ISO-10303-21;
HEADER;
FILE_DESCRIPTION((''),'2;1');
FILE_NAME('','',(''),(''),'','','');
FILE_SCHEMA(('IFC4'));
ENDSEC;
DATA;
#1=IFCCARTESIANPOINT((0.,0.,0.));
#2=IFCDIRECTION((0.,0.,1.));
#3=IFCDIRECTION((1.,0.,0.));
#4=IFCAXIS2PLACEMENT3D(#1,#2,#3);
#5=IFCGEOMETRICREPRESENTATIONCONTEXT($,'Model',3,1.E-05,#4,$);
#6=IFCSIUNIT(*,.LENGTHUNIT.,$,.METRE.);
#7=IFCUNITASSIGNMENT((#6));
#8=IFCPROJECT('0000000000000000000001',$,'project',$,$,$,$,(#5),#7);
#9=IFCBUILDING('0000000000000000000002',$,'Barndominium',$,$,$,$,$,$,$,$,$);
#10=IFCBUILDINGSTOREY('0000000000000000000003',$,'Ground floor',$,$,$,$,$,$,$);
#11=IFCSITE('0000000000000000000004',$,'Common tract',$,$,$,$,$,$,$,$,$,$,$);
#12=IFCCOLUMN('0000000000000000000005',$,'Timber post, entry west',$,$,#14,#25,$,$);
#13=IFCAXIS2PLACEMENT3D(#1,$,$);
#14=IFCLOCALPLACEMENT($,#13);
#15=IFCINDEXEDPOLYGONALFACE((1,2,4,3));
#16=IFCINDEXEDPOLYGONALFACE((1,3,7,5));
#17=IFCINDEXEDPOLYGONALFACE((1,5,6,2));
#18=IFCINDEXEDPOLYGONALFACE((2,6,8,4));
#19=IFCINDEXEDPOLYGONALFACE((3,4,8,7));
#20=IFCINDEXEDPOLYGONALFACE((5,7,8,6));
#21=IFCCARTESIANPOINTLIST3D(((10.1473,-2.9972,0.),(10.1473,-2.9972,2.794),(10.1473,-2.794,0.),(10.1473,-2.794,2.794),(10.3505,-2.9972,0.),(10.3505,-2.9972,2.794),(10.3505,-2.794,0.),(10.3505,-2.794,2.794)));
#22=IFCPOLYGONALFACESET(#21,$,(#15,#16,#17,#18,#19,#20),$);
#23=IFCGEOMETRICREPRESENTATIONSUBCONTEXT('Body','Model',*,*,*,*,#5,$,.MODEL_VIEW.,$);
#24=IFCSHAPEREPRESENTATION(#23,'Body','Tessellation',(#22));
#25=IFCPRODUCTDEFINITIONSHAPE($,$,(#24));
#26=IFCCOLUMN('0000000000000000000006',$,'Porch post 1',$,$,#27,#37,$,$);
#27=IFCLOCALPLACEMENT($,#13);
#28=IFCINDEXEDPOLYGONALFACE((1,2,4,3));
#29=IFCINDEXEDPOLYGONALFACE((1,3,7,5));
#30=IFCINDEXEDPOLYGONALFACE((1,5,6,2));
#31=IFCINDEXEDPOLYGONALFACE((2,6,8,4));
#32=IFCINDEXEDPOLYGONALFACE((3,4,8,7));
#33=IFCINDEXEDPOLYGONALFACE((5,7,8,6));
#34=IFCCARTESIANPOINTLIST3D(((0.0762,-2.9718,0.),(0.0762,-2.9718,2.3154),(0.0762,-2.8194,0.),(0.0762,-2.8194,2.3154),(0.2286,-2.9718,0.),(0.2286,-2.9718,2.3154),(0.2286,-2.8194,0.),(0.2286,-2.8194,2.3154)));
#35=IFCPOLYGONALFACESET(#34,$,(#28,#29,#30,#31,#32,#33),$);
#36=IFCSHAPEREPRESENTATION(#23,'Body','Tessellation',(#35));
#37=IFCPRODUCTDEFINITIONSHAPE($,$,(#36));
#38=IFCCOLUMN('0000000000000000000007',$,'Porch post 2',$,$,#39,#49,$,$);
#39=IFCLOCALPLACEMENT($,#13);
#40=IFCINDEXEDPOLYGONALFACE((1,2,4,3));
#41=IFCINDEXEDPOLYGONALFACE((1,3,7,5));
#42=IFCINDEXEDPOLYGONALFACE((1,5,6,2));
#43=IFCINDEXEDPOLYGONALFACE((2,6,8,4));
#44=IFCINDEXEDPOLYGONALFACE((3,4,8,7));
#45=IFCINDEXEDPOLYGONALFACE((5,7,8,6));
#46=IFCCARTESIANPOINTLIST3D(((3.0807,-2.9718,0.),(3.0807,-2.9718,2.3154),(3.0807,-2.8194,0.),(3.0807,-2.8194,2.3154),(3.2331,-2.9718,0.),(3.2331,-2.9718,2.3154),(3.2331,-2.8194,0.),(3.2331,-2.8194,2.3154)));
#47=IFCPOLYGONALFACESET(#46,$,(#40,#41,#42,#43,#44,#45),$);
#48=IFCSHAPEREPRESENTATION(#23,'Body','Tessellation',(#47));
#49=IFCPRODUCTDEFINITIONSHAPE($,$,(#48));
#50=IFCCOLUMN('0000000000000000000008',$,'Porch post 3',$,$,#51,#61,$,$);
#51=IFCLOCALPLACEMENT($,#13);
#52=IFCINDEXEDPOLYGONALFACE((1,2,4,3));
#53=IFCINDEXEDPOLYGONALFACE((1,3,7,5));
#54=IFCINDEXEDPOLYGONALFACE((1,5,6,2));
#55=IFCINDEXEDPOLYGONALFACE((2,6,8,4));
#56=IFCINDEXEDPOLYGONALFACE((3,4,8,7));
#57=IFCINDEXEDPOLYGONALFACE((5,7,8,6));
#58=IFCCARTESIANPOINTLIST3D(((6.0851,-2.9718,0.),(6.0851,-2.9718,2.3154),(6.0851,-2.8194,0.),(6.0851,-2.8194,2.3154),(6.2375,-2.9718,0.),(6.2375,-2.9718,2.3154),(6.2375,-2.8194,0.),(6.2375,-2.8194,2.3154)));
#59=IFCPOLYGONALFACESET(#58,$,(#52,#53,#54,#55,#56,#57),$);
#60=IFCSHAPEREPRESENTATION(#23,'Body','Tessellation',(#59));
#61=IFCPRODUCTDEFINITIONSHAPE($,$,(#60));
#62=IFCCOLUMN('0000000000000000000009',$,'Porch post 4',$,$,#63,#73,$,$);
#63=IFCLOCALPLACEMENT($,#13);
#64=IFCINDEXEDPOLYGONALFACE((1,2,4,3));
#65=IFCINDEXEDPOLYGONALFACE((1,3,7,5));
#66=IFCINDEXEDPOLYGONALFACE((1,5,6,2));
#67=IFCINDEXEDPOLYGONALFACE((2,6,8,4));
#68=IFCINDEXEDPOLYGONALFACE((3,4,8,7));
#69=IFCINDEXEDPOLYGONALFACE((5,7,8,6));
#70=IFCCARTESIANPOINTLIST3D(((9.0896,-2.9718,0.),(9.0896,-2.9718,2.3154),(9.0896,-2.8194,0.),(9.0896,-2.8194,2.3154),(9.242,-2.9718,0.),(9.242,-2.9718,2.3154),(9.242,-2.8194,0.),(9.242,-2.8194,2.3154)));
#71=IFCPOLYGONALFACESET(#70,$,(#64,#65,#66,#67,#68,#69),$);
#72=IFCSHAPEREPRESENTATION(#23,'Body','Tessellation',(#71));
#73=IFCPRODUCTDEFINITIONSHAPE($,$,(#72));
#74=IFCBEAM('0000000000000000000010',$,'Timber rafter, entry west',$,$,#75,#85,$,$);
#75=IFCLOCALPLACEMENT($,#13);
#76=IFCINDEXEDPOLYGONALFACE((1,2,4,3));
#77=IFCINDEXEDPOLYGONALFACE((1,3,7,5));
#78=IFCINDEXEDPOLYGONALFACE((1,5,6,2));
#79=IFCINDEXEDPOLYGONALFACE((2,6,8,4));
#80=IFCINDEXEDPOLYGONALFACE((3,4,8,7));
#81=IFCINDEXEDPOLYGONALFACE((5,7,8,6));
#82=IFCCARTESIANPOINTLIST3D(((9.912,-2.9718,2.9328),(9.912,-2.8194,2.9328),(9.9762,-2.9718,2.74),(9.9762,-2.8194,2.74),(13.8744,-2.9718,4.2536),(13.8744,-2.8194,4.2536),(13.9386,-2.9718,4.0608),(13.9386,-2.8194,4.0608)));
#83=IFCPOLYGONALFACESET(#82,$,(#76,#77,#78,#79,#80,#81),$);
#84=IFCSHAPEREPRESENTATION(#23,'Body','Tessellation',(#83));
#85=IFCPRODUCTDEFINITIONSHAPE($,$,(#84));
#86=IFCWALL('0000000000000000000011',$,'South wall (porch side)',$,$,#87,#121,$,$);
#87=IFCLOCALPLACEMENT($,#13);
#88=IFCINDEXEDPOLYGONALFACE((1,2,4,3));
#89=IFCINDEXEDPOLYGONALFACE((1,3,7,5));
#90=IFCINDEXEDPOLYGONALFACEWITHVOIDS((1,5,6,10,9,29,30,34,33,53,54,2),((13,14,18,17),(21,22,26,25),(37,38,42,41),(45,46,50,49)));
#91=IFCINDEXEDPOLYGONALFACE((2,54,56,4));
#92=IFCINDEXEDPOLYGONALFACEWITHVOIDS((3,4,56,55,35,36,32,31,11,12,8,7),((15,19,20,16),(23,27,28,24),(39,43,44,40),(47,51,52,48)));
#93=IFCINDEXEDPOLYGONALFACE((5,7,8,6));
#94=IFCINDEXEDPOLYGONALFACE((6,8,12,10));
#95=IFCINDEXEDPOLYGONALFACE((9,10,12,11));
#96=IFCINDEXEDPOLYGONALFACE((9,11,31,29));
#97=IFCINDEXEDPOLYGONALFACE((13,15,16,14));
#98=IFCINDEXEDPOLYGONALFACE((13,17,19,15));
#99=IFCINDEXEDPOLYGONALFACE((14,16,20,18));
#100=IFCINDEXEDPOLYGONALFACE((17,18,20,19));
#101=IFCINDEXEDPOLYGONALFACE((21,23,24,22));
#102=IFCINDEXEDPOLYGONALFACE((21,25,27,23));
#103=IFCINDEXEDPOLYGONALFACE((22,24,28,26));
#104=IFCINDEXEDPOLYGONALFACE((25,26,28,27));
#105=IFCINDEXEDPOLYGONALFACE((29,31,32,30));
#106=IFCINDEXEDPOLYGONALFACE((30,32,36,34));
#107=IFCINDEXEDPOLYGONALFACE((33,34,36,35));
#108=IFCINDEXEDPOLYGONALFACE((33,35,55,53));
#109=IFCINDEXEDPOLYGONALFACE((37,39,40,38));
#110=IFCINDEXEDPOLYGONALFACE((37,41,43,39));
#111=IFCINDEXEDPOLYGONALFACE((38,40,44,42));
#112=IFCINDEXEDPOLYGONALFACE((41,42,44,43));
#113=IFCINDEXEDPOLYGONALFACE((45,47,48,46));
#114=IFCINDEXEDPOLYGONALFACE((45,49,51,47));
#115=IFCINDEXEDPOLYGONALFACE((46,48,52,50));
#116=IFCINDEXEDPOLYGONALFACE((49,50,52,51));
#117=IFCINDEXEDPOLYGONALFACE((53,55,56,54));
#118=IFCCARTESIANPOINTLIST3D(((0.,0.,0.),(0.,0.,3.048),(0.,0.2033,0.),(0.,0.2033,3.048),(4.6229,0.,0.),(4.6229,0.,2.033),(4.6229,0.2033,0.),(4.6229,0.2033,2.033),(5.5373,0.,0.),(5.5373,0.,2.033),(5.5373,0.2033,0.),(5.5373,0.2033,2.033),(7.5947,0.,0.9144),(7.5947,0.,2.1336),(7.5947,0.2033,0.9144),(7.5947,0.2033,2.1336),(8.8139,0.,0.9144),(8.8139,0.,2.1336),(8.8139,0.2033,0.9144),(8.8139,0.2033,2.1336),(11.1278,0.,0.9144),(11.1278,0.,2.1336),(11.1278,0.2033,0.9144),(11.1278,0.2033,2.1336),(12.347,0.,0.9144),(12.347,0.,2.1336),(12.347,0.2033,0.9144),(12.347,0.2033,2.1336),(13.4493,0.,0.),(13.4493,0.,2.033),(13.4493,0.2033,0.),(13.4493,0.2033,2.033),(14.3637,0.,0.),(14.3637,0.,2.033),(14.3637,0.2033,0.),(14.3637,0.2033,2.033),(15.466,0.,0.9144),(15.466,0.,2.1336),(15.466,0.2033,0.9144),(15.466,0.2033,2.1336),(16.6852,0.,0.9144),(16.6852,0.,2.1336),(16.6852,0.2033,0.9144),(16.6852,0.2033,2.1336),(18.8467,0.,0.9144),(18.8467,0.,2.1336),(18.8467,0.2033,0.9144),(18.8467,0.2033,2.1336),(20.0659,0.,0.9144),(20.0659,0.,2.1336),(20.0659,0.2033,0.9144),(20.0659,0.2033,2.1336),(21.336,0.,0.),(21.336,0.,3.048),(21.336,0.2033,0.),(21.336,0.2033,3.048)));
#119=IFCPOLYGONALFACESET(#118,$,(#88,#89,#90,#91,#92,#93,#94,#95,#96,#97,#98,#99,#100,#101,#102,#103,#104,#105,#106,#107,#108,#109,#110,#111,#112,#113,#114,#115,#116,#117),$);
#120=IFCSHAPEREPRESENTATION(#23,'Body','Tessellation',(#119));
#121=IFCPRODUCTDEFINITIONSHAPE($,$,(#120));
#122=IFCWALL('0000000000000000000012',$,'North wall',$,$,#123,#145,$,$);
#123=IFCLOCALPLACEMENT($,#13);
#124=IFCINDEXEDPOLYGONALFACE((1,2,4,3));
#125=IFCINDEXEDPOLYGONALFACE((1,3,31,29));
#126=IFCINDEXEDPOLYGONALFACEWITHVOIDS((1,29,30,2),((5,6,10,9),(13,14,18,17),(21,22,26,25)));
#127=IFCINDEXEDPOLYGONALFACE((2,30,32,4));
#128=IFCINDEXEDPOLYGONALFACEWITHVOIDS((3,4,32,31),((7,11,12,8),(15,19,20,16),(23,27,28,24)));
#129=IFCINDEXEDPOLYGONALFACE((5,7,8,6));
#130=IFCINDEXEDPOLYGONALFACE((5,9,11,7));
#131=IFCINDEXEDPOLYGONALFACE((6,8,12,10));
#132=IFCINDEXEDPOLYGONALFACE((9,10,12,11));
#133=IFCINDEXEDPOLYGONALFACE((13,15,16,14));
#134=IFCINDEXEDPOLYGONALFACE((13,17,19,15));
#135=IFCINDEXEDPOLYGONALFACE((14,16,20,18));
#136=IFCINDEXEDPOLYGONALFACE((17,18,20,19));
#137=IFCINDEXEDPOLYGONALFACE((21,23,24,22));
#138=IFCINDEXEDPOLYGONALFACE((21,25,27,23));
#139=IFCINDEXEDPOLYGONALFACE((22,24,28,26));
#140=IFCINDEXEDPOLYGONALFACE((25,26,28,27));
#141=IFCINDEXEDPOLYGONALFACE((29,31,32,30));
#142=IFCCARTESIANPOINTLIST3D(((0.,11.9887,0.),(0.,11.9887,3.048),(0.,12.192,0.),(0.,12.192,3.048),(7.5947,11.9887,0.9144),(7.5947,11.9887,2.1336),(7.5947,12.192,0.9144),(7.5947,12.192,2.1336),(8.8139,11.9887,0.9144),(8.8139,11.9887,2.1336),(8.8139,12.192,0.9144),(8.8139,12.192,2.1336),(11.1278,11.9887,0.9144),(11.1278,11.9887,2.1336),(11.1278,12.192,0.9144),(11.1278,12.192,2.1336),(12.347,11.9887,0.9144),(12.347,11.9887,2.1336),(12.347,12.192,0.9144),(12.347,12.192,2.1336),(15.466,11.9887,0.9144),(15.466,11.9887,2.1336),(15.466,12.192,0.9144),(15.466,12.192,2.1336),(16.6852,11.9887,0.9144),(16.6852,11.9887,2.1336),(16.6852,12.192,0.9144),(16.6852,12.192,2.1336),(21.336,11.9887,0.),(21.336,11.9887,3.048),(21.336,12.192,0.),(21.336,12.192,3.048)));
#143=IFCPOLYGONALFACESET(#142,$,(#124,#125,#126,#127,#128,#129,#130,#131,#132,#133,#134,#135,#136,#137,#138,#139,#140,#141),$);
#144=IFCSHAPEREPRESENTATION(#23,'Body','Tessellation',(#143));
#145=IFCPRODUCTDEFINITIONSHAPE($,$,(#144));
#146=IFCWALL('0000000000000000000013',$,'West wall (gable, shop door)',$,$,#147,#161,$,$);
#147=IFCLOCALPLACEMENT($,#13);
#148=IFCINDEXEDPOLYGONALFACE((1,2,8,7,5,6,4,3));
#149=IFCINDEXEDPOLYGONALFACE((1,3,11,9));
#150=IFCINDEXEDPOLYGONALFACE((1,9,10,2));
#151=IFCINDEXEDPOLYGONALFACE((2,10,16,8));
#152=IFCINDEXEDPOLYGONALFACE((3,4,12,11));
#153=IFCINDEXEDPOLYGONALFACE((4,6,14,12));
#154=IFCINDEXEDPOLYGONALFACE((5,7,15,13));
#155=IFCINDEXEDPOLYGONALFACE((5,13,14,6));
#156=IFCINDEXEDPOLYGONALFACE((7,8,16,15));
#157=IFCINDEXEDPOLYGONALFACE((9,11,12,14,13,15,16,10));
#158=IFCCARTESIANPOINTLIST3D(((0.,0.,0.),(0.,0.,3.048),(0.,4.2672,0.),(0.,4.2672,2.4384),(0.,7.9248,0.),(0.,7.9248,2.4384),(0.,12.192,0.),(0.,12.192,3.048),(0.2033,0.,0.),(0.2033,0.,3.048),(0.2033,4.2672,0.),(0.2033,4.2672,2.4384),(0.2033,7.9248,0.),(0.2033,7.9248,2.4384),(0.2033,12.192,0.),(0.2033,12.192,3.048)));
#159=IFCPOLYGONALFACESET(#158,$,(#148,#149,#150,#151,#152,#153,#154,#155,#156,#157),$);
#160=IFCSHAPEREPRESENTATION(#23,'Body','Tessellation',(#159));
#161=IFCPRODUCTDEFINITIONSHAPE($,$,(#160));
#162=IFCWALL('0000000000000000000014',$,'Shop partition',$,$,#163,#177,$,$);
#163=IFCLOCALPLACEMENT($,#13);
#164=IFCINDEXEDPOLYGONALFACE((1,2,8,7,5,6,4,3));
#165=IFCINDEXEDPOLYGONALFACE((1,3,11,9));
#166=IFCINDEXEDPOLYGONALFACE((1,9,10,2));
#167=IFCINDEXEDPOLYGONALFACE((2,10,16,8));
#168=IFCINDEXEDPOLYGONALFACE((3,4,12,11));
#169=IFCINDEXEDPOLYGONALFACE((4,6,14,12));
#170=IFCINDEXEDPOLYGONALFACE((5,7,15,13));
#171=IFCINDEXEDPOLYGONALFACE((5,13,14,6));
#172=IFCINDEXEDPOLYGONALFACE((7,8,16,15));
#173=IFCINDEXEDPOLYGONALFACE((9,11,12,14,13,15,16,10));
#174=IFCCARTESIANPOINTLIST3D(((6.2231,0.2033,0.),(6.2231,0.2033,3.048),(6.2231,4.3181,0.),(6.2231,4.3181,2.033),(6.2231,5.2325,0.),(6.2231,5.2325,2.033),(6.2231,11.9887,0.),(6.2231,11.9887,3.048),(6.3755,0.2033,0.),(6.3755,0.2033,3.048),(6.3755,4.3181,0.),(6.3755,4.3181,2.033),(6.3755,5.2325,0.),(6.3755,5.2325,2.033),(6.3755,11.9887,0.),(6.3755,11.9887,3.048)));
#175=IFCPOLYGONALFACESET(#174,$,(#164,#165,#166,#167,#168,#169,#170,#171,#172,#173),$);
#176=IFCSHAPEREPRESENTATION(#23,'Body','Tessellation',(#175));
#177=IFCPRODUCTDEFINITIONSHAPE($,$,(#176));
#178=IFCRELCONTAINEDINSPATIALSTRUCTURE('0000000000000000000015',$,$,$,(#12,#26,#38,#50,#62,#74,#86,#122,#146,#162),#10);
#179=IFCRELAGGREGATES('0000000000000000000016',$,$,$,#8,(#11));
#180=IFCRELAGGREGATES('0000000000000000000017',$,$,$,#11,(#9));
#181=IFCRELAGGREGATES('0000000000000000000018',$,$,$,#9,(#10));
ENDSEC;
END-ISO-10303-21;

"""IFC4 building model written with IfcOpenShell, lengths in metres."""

from ifc_helpers import new_model, si_unit, frame, origin_with_axes, place, context, subcontext, project, spatial, indexed_curve, rectangle, outline, extrude, element, save


model = new_model("IFC4")

# Units and contexts
model_context = context("Model", 3, precision=1e-05, world=origin_with_axes())
body_context = subcontext(model_context, "Body", "Model", "MODEL_VIEW")
ifc_project = project(units=[si_unit("LENGTHUNIT", "METRE")], contexts=[model_context])

# Site, building, storey
site = spatial("IfcSite", under=ifc_project, Name="Common tract")
building = spatial("IfcBuilding", under=site, Name="Barndominium")
storey = spatial("IfcBuildingStorey", under=building, Name="Ground floor")

# Columns
column_placement = place(None, frame((10.2489, -2.8956, 0.0), z_axis=(0.0, 0.0, 1.0), x_axis=(1.0, 0.0, 0.0)))
element("IfcColumn", 1, at=column_placement, inside=storey, Name="Timber post, entry west", context=body_context, shape_type="SweptSolid", body=[
    extrude(rectangle(XDim=0.2032, YDim=0.2032), origin_with_axes(), (0.0, 0.0, 1.0), 2.794),
])
for number, where, z_axis, x_axis, name in (
    (2, (0.1524, -2.8956, 0.0), (0.0, 0.0, 1.0), (1.0, 0.0, 0.0), "Porch post 1"),
    (3, (3.1569, -2.8956, 0.0), (0.0, 0.0, 1.0), (1.0, 0.0, 0.0), "Porch post 2"),
    (4, (6.1613, -2.8956, 0.0), (0.0, 0.0, 1.0), (1.0, 0.0, 0.0), "Porch post 3"),
    (5, (9.1658, -2.8956, 0.0), (0.0, 0.0, 1.0), (1.0, 0.0, 0.0), "Porch post 4"),
):
    element("IfcColumn", number, at=place(None, frame(where, z_axis=z_axis, x_axis=x_axis)), inside=storey, Name=name, context=body_context, shape_type="SweptSolid", body=[
        extrude(rectangle(XDim=0.1524, YDim=0.1524), origin_with_axes(), (0.0, 0.0, 1.0), 2.3154),
    ])

# Beam
beam_placement = place(None, frame((9.9441, -2.8956, 2.8364), z_axis=(0.948683, 0.0, 0.316228), x_axis=(0.0, 1.0, 0.0)))
element("IfcBeam", 6, at=beam_placement, inside=storey, Name="Timber rafter, entry west", context=body_context, shape_type="SweptSolid", body=[
    extrude(rectangle(XDim=0.1524, YDim=0.2032), origin_with_axes(), (0.0, 0.0, 1.0), 4.1767),
])

# Walls, openings
wall_1_placement = place(None, origin_with_axes())
wall_1 = element("IfcWall", 7, at=wall_1_placement, inside=storey, Name="South wall (porch side)", context=body_context, shape_type="SweptSolid", body=[
    extrude(outline(indexed_curve([(0.0, 0.0), (0.0, 0.2033), (21.336, 0.2033), (21.336, 0.0), (0.0, 0.0)], self_intersect=False)), origin_with_axes(), (0.0, 0.0, 1.0), 3.048),
])
opening_1_placement = place(wall_1_placement, frame((5.0801, 0.1017, 0.0), z_axis=(0.0, 0.0, 1.0), x_axis=(1.0, 0.0, 0.0)))
element("IfcOpeningElement", 8, at=opening_1_placement, cuts=wall_1, context=body_context, shape_type="SweptSolid", body=[
    extrude(rectangle(XDim=0.9144, YDim=0.3033), origin_with_axes(), (0.0, 0.0, 1.0), 2.033),
])
opening_2_placement = place(wall_1_placement, frame((13.9065, 0.1017, 0.0), z_axis=(0.0, 0.0, 1.0), x_axis=(1.0, 0.0, 0.0)))
element("IfcOpeningElement", 9, at=opening_2_placement, cuts=wall_1, context=body_context, shape_type="SweptSolid", body=[
    extrude(rectangle(XDim=0.9144, YDim=0.3033), origin_with_axes(), (0.0, 0.0, 1.0), 2.033),
])
opening_3_placement = place(wall_1_placement, frame((8.2043, 0.1017, 0.9144), z_axis=(0.0, 0.0, 1.0), x_axis=(1.0, 0.0, 0.0)))
element("IfcOpeningElement", 10, at=opening_3_placement, cuts=wall_1, context=body_context, shape_type="SweptSolid", body=[
    extrude(rectangle(XDim=1.2192, YDim=0.3033), origin_with_axes(), (0.0, 0.0, 1.0), 1.2192),
])
opening_4_placement = place(wall_1_placement, frame((11.7374, 0.1017, 0.9144), z_axis=(0.0, 0.0, 1.0), x_axis=(1.0, 0.0, 0.0)))
element("IfcOpeningElement", 11, at=opening_4_placement, cuts=wall_1, context=body_context, shape_type="SweptSolid", body=[
    extrude(rectangle(XDim=1.2192, YDim=0.3033), origin_with_axes(), (0.0, 0.0, 1.0), 1.2192),
])
opening_5_placement = place(wall_1_placement, frame((16.0756, 0.1017, 0.9144), z_axis=(0.0, 0.0, 1.0), x_axis=(1.0, 0.0, 0.0)))
element("IfcOpeningElement", 12, at=opening_5_placement, cuts=wall_1, context=body_context, shape_type="SweptSolid", body=[
    extrude(rectangle(XDim=1.2192, YDim=0.3033), origin_with_axes(), (0.0, 0.0, 1.0), 1.2192),
])
opening_6_placement = place(wall_1_placement, frame((19.4563, 0.1017, 0.9144), z_axis=(0.0, 0.0, 1.0), x_axis=(1.0, 0.0, 0.0)))
element("IfcOpeningElement", 13, at=opening_6_placement, cuts=wall_1, context=body_context, shape_type="SweptSolid", body=[
    extrude(rectangle(XDim=1.2192, YDim=0.3033), origin_with_axes(), (0.0, 0.0, 1.0), 1.2192),
])
wall_2_placement = place(None, frame((0.0, 11.9887, 0.0), z_axis=(0.0, 0.0, 1.0), x_axis=(1.0, 0.0, 0.0)))
wall_2 = element("IfcWall", 14, at=wall_2_placement, inside=storey, Name="North wall", context=body_context, shape_type="SweptSolid", body=[
    extrude(outline(indexed_curve([(0.0, 0.0), (0.0, 0.2033), (21.336, 0.2033), (21.336, 0.0), (0.0, 0.0)], self_intersect=False)), origin_with_axes(), (0.0, 0.0, 1.0), 3.048),
])
opening_7_placement = place(wall_2_placement, frame((8.2043, 0.1017, 0.9144), z_axis=(0.0, 0.0, 1.0), x_axis=(1.0, 0.0, 0.0)))
element("IfcOpeningElement", 15, at=opening_7_placement, cuts=wall_2, context=body_context, shape_type="SweptSolid", body=[
    extrude(rectangle(XDim=1.2192, YDim=0.3033), origin_with_axes(), (0.0, 0.0, 1.0), 1.2192),
])
opening_8_placement = place(wall_2_placement, frame((16.0756, 0.1017, 0.9144), z_axis=(0.0, 0.0, 1.0), x_axis=(1.0, 0.0, 0.0)))
element("IfcOpeningElement", 16, at=opening_8_placement, cuts=wall_2, context=body_context, shape_type="SweptSolid", body=[
    extrude(rectangle(XDim=1.2192, YDim=0.3033), origin_with_axes(), (0.0, 0.0, 1.0), 1.2192),
])
opening_9_placement = place(wall_2_placement, frame((11.7374, 0.1017, 0.9144), z_axis=(0.0, 0.0, 1.0), x_axis=(1.0, 0.0, 0.0)))
element("IfcOpeningElement", 17, at=opening_9_placement, cuts=wall_2, context=body_context, shape_type="SweptSolid", body=[
    extrude(rectangle(XDim=1.2192, YDim=0.3033), origin_with_axes(), (0.0, 0.0, 1.0), 1.2192),
])

# Walls, openings
wall_3_placement = place(None, frame((0.2033, 0.0, 0.0), z_axis=(0.0, 0.0, 1.0), x_axis=(0.0, 1.0, 0.0)))
wall_3 = element("IfcWall", 18, at=wall_3_placement, inside=storey, Name="West wall (gable, shop door)", context=body_context, shape_type="SweptSolid", body=[
    extrude(outline(indexed_curve([(0.0, 0.0), (0.0, 0.2033), (12.192, 0.2033), (12.192, 0.0), (0.0, 0.0)], self_intersect=False)), origin_with_axes(), (0.0, 0.0, 1.0), 3.048),
])
opening_10_placement = place(wall_3_placement, frame((6.096, 0.1017, 0.0), z_axis=(0.0, 0.0, 1.0), x_axis=(0.0, -1.0, 0.0)))
element("IfcOpeningElement", 19, at=opening_10_placement, cuts=wall_3, context=body_context, shape_type="SweptSolid", body=[
    extrude(rectangle(XDim=0.3033, YDim=3.6576), origin_with_axes(), (0.0, 0.0, 1.0), 2.4384),
])
wall_4_placement = place(None, frame((6.3755, 0.2033, 0.0), z_axis=(0.0, 0.0, 1.0), x_axis=(0.0, 1.0, 0.0)))
wall_4 = element("IfcWall", 20, at=wall_4_placement, inside=storey, Name="Shop partition", context=body_context, shape_type="SweptSolid", body=[
    extrude(outline(indexed_curve([(0.0, 0.0), (0.0, 0.1524), (11.7854, 0.1524), (11.7854, 0.0), (0.0, 0.0)], self_intersect=False)), origin_with_axes(), (0.0, 0.0, 1.0), 3.048),
])
opening_11_placement = place(wall_4_placement, frame((4.572, 0.0762, 0.0), z_axis=(0.0, 0.0, 1.0), x_axis=(0.0, -1.0, 0.0)))
element("IfcOpeningElement", 21, at=opening_11_placement, cuts=wall_4, context=body_context, shape_type="SweptSolid", body=[
    extrude(rectangle(XDim=0.3033, YDim=0.9144), origin_with_axes(), (0.0, 0.0, 1.0), 2.033),
])

save(model, "model.ifc")
